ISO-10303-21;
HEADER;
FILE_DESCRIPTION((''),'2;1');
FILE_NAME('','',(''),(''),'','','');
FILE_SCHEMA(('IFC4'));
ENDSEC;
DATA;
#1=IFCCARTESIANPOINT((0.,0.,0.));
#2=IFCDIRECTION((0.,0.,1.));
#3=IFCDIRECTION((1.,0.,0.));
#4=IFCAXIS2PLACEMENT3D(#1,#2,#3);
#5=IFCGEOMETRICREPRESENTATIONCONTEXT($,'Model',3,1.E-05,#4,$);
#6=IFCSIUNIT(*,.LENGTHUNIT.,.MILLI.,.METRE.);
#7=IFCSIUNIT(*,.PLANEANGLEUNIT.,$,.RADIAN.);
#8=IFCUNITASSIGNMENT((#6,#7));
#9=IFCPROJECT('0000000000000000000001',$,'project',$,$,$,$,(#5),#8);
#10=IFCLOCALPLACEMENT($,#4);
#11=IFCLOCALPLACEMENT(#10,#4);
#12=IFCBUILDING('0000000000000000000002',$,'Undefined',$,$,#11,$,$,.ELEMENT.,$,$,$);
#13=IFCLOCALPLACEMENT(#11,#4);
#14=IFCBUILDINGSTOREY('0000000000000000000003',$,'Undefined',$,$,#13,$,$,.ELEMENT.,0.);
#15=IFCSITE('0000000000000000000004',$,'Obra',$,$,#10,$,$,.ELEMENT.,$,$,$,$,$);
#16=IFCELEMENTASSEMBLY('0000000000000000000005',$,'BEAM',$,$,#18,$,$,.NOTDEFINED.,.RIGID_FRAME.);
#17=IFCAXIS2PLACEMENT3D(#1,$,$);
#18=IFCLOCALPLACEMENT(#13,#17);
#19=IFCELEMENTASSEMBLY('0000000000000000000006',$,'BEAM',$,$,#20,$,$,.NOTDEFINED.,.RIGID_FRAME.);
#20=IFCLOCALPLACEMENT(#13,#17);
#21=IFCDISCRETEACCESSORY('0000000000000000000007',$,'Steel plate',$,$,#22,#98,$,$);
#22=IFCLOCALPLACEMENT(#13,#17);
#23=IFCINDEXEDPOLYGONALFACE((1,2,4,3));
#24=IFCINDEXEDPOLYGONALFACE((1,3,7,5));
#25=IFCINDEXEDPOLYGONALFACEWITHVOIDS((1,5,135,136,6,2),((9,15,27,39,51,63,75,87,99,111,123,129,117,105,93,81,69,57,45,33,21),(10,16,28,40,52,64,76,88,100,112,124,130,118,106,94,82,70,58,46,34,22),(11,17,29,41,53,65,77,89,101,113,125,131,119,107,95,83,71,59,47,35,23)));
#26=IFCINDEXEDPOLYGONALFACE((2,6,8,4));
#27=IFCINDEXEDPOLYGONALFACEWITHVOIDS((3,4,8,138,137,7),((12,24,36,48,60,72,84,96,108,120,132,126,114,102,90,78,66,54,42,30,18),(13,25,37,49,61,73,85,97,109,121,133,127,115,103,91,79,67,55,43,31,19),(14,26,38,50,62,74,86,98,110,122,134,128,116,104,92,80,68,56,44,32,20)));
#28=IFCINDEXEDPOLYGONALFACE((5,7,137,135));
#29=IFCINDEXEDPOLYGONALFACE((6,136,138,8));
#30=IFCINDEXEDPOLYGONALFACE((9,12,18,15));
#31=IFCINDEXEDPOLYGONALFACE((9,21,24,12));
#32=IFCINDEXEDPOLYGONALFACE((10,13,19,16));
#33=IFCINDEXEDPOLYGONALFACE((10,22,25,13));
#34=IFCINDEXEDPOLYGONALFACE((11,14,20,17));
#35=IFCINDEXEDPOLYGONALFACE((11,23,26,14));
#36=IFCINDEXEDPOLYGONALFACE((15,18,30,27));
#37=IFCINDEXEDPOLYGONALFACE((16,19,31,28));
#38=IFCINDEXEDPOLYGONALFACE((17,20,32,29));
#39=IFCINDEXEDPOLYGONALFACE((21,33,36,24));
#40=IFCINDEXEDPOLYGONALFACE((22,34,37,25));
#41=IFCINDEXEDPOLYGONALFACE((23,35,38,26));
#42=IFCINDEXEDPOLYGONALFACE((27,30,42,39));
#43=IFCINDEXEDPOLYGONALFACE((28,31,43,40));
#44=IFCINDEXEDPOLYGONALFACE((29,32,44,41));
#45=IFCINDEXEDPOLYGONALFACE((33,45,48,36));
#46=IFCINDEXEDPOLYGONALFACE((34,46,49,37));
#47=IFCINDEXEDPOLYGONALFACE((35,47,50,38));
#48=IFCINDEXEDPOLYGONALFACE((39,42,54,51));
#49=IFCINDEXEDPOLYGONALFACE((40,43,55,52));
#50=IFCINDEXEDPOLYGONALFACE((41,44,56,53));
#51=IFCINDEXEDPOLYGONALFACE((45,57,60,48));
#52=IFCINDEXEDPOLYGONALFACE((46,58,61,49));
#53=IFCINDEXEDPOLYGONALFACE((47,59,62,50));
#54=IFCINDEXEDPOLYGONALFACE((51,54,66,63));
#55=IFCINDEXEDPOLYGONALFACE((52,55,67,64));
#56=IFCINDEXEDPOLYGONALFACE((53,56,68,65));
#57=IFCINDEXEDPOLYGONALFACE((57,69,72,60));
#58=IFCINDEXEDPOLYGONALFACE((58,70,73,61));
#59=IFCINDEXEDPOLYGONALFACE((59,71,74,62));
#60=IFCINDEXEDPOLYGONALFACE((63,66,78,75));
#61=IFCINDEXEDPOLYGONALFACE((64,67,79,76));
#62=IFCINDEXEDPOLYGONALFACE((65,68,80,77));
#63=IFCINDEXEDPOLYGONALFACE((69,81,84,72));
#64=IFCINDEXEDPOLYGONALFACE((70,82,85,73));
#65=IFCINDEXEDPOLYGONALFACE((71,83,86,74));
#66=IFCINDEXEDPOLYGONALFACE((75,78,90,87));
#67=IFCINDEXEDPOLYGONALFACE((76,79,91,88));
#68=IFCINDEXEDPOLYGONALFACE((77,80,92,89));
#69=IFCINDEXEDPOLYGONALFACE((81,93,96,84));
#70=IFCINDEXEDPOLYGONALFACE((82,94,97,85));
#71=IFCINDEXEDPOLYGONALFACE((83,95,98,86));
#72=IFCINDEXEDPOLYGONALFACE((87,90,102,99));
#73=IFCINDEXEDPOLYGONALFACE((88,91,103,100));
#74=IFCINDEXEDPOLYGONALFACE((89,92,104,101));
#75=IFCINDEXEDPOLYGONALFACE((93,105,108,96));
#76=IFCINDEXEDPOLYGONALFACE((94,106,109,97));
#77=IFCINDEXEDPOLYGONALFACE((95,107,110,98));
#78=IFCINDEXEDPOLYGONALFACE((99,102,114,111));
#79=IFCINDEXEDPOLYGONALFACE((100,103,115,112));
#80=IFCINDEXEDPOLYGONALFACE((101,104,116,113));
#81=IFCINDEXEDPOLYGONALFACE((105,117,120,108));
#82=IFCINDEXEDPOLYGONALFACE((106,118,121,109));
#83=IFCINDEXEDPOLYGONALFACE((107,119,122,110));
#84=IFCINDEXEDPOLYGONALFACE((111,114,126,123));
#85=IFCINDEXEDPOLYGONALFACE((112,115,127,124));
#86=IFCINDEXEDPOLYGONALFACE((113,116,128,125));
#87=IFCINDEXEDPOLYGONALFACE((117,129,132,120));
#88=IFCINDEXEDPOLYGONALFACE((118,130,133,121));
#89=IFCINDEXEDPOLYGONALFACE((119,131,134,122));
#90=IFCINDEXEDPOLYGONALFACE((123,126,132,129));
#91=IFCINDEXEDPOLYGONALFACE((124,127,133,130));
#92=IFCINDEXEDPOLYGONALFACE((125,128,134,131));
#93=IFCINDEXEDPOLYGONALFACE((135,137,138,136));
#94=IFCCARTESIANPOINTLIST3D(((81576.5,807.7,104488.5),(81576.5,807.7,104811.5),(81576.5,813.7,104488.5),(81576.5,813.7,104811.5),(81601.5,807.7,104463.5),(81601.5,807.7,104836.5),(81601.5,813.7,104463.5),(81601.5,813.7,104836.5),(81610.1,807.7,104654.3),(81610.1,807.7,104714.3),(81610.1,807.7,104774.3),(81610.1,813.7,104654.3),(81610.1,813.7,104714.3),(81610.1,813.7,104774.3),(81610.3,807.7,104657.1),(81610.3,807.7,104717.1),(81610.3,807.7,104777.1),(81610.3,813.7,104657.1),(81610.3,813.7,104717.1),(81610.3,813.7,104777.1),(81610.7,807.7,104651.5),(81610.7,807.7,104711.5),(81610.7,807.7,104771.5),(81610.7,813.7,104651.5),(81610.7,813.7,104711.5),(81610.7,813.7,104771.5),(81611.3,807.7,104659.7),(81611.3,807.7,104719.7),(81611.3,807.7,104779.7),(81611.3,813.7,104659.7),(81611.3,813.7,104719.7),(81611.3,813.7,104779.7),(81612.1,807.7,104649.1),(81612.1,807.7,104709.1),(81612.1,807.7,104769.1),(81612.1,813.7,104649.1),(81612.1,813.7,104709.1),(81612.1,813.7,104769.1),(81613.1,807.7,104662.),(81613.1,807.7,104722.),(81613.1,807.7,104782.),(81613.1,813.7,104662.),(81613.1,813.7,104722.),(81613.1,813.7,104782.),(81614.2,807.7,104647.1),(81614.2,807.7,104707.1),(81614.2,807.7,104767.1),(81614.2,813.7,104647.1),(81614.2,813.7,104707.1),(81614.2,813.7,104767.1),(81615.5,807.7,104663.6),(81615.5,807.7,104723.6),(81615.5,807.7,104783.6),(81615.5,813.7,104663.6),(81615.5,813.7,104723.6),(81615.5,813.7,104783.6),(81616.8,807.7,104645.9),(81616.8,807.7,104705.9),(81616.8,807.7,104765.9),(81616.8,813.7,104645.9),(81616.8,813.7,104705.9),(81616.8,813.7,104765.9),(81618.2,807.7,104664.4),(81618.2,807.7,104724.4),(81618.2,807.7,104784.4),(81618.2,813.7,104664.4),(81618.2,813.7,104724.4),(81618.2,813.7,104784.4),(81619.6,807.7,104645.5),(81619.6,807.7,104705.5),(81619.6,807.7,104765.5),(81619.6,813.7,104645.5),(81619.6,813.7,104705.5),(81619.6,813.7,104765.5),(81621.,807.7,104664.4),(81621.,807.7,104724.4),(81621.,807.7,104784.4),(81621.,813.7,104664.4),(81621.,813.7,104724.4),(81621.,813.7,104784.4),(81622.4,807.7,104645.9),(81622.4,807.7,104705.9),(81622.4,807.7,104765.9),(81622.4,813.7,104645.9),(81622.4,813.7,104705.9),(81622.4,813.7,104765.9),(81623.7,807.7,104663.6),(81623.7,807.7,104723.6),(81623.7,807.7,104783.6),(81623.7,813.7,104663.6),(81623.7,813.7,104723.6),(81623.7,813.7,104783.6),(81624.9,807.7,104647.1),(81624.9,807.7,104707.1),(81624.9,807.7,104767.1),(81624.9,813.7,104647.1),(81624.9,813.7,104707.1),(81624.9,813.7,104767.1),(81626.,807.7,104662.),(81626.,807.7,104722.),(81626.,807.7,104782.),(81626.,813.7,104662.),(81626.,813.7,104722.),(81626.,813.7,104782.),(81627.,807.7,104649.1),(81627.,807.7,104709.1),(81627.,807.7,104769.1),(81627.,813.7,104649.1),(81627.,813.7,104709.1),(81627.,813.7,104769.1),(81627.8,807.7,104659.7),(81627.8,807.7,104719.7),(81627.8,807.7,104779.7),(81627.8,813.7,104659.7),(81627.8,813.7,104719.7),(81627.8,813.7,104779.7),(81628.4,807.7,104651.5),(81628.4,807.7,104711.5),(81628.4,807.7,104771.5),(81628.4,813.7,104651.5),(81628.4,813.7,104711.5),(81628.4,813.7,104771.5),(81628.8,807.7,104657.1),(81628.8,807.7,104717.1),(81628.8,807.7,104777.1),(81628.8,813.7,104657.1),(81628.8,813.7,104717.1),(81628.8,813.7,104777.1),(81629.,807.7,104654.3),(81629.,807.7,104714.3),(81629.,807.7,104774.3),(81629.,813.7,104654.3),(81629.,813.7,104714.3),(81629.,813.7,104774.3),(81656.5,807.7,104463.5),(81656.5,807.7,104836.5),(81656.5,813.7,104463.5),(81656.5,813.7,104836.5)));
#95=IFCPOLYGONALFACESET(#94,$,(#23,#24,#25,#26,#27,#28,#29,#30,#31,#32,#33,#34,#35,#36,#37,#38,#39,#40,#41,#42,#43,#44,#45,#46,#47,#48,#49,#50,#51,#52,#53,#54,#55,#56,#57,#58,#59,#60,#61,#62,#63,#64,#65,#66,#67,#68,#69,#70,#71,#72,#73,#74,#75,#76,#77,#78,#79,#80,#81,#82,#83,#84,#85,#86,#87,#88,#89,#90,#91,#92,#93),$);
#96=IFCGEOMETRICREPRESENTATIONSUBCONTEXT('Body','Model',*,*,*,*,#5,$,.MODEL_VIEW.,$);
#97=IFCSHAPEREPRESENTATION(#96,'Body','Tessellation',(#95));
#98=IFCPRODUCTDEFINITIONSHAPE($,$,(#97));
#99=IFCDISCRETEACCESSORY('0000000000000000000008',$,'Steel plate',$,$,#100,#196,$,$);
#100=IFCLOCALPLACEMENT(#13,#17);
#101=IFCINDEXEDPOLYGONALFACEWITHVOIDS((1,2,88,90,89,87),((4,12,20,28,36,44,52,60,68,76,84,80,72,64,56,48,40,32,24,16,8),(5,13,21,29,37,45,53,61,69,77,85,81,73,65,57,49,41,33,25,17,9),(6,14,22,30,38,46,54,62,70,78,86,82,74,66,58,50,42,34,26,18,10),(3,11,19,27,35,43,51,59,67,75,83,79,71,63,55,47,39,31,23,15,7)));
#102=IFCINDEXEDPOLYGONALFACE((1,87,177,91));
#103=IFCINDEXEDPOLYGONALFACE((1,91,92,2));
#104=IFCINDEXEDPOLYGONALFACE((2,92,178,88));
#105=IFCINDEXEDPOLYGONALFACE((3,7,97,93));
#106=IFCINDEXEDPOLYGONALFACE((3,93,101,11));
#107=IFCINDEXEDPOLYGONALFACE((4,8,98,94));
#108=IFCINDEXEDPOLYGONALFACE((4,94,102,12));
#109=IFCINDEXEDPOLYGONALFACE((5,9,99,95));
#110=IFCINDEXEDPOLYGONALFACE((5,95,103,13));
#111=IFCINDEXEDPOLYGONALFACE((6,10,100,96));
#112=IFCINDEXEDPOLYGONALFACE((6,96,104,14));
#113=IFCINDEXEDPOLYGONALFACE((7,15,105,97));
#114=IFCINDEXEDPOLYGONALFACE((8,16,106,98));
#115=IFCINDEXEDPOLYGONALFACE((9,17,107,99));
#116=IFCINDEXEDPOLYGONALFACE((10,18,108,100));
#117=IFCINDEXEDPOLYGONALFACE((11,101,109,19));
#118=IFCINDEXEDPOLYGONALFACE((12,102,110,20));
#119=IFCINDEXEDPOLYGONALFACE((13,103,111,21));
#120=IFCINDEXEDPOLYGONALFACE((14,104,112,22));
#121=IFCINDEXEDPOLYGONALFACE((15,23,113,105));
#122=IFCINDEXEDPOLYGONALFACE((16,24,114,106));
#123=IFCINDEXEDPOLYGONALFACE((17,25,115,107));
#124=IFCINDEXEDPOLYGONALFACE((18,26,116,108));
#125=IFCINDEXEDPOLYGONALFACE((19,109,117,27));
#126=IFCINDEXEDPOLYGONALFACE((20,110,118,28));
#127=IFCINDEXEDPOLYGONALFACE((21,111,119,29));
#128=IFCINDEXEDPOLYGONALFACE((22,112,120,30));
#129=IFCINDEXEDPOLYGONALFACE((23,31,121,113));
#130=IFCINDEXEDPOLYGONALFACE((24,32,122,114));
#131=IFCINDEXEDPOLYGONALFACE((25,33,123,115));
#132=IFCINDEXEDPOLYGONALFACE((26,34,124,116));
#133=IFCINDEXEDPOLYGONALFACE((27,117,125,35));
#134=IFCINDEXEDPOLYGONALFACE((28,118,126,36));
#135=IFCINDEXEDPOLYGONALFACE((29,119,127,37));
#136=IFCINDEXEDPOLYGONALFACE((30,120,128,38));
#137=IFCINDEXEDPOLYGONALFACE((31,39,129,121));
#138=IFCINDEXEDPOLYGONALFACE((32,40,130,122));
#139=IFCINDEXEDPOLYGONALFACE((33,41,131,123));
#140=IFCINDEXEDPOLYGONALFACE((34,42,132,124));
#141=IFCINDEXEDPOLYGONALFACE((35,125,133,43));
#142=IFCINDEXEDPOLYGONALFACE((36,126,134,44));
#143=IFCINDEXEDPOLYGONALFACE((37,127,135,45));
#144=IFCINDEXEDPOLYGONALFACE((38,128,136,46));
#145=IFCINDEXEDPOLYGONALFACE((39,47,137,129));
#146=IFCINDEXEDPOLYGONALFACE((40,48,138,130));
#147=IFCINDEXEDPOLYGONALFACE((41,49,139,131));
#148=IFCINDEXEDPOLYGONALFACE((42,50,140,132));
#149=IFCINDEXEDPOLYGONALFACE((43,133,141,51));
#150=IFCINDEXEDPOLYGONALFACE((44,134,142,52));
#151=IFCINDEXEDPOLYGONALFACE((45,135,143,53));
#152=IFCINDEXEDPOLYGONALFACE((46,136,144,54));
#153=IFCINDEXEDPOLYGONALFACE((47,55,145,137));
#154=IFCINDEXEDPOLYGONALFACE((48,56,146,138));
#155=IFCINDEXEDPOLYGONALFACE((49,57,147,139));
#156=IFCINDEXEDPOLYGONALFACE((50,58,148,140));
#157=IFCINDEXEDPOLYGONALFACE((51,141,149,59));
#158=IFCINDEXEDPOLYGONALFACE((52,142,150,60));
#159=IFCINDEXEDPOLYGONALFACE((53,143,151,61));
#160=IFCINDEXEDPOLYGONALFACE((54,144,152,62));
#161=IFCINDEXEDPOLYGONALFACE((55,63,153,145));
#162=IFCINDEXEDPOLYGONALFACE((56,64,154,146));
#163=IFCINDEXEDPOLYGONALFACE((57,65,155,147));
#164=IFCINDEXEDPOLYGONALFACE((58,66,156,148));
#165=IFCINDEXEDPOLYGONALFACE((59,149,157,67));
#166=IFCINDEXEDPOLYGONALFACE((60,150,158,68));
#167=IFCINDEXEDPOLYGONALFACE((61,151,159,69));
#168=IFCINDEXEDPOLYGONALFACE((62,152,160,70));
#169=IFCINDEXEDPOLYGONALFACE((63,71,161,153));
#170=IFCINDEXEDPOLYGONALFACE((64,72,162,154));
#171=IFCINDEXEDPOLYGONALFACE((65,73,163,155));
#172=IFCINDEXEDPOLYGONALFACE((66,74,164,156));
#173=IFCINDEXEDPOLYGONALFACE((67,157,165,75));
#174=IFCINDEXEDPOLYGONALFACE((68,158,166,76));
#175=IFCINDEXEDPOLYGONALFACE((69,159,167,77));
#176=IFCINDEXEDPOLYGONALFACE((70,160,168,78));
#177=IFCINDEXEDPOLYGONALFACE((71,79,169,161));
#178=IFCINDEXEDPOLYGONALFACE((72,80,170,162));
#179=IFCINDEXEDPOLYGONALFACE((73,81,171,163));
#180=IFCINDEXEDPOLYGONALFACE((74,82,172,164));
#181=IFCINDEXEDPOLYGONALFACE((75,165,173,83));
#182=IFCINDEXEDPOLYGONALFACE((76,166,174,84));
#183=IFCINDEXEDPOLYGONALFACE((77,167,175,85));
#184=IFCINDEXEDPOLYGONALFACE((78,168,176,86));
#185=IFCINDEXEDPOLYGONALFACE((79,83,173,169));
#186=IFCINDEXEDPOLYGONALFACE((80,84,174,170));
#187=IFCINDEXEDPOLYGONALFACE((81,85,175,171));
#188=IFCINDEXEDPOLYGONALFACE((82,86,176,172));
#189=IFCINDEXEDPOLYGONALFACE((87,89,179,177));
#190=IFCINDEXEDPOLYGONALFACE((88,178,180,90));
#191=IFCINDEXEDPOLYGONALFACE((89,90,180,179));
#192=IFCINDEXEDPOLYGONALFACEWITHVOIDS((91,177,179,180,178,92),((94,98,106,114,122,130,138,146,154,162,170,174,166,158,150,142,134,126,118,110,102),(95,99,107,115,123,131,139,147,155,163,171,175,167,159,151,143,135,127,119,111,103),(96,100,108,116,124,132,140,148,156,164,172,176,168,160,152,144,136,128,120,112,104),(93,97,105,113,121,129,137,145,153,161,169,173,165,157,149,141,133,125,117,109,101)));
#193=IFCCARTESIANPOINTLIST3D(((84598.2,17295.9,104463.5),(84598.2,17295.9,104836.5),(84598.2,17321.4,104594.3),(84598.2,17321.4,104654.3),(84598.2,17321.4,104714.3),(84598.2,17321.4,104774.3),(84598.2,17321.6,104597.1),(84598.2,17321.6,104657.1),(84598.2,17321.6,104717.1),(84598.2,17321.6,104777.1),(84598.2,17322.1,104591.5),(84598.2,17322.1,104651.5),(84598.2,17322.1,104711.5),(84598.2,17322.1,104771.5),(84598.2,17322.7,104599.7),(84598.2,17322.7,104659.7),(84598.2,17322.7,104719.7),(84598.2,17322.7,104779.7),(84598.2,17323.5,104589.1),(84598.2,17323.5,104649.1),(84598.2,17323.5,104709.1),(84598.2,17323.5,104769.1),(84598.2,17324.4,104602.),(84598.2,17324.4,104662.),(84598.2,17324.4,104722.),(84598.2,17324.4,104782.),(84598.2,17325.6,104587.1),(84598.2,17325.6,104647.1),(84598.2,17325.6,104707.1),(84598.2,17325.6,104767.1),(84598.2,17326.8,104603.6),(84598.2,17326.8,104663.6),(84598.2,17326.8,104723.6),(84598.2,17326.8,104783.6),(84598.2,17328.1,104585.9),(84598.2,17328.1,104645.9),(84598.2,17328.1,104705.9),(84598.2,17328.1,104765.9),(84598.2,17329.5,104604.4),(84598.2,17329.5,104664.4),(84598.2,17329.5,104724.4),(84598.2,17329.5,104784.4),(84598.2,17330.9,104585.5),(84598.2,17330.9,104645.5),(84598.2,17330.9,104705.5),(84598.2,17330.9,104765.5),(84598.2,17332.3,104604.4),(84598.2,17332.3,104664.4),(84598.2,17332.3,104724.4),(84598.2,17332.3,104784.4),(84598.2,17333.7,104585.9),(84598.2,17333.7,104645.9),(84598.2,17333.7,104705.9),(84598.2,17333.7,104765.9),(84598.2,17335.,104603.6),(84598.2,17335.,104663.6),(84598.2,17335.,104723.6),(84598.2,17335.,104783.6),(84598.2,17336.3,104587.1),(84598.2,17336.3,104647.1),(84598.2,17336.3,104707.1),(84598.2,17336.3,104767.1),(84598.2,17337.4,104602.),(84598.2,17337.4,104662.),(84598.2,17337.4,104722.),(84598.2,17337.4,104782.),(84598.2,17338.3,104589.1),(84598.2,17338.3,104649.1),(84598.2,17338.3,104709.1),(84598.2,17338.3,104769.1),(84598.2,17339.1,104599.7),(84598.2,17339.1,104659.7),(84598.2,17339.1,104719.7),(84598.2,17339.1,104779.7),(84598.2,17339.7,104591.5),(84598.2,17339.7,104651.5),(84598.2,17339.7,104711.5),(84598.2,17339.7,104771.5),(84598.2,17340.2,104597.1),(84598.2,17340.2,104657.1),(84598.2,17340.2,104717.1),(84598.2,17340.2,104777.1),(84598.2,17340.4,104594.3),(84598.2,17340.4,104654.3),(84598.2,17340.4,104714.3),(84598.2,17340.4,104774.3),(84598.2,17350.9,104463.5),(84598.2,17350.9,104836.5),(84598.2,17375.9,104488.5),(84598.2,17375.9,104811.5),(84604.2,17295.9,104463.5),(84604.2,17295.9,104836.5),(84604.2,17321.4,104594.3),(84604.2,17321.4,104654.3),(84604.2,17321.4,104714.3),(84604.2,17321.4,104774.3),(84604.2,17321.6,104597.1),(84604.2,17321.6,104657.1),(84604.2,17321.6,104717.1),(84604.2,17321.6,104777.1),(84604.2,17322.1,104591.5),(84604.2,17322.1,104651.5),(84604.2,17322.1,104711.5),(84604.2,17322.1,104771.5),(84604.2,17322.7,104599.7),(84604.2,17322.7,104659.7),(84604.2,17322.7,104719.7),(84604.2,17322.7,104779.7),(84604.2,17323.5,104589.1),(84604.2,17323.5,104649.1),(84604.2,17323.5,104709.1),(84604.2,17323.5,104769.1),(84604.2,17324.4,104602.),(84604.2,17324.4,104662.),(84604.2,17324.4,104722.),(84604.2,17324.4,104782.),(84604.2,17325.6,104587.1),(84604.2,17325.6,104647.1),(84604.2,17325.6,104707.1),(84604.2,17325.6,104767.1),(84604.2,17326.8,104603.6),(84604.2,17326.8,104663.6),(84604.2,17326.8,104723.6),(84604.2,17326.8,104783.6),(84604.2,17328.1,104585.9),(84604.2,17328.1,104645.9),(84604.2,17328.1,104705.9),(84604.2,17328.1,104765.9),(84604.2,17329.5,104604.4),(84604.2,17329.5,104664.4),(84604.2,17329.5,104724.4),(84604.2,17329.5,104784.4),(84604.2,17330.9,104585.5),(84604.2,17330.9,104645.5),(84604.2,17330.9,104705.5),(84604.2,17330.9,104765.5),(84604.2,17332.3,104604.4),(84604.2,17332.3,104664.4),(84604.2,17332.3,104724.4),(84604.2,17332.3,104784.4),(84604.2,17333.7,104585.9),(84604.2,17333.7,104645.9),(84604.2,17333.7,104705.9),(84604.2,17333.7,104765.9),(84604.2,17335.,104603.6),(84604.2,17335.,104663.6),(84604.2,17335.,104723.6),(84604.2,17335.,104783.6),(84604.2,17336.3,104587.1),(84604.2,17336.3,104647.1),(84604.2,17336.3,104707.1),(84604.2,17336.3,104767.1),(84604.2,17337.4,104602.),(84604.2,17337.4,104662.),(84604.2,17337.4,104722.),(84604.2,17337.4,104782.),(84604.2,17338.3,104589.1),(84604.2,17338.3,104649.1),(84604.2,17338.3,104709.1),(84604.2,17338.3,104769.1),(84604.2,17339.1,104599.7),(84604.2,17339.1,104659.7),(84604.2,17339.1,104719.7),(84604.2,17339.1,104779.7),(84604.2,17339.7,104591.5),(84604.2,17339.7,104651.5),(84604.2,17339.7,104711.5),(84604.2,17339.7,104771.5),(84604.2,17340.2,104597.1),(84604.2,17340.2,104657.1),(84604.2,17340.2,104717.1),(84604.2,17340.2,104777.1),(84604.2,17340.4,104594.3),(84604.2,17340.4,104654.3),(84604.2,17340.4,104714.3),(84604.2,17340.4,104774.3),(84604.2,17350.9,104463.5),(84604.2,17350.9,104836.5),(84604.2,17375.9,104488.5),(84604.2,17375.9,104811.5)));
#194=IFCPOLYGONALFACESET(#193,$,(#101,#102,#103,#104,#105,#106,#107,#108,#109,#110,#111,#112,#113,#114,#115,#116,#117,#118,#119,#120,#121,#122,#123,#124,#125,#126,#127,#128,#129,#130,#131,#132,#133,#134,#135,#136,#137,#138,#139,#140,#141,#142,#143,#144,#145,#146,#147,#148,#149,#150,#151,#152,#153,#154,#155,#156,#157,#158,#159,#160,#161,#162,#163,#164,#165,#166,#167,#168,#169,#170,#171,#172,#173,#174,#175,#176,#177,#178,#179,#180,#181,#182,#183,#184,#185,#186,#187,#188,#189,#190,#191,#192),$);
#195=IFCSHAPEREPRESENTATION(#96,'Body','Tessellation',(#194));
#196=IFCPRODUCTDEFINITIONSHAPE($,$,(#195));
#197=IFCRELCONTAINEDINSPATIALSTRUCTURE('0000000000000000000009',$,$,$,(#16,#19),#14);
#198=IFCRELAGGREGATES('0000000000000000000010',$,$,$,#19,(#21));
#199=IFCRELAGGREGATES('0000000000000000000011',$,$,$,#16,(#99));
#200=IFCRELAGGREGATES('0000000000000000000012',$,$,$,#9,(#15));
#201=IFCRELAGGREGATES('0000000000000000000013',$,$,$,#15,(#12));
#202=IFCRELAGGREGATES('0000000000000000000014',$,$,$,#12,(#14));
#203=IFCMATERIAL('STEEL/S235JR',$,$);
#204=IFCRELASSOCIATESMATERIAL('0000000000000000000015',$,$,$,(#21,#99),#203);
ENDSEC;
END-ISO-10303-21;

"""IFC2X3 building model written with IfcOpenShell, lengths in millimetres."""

from ifc_helpers import new_model, si_unit, frame, origin_with_axes, origin_2d_with_axis, place, context, subcontext, project, spatial, polyline, circle, outline, extrude, source, transform, mapped, material, element, aggregate, save


model = new_model("IFC2X3")

# Units and contexts
model_context = context("Model", 3, precision=1e-05, world=origin_with_axes())
body_context = subcontext(model_context, "Body", "Model", "MODEL_VIEW")
ifc_project = project(units=[si_unit("LENGTHUNIT", "METRE", prefix="MILLI"), si_unit("PLANEANGLEUNIT", "RADIAN")], contexts=[model_context])

# Site, building, storey
site_placement = place(None, origin_with_axes())
site = spatial("IfcSite", under=ifc_project, at=site_placement, Name="Obra", CompositionType="ELEMENT")
building_placement = place(site_placement, origin_with_axes())
building = spatial("IfcBuilding", under=site, at=building_placement, Name="Undefined", CompositionType="ELEMENT")
storey_placement = place(building_placement, origin_with_axes())
storey = spatial("IfcBuildingStorey", under=building, at=storey_placement, Name="Undefined", CompositionType="ELEMENT", Elevation=0.0)

# Shared definitions
ifc_material = material(Name="STEEL/S235JR")

# Element assembly
assembly_1_placement = place(storey_placement, origin_with_axes())
assembly_1 = element("IfcElementAssembly", 1, at=assembly_1_placement, inside=storey, Name="BEAM", AssemblyPlace="NOTDEFINED", PredefinedType="RIGID_FRAME")

# Element assembly, discrete accessory, opening
assembly_2_placement = place(storey_placement, origin_with_axes())
assembly_2 = element("IfcElementAssembly", 2, at=assembly_2_placement, inside=storey, Name="BEAM", AssemblyPlace="NOTDEFINED", PredefinedType="RIGID_FRAME")
discrete_accessory_1_placement = place(assembly_2_placement, frame((81656.5, 810.7, 104463.5), z_axis=(0.0, 1.0, 0.0), x_axis=(-1.0, 0.0, 0.0)))
discrete_accessory_1 = element("IfcDiscreteAccessory", 3, at=discrete_accessory_1_placement, material=ifc_material, Name="Steel plate", context=body_context, shape_type="SweptSolid", body=[
    extrude(outline(polyline([(0.0, 0.0), (55.0, 0.0), (80.0, 25.0), (80.0, 348.0), (55.0, 373.0), (0.0, 373.0), (0.0, 0.0)])), frame((0.0, 0.0, -3.0), z_axis=(0.0, 0.0, 1.0), x_axis=(1.0, 0.0, 0.0)), (0.0, 0.0, 1.0), 6.0),
])
shared_shape_1 = source(origin_with_axes(), body_context, "Body", "SweptSolid", [
    extrude(circle(Radius=9.5, at=origin_2d_with_axis()), frame((0.0, -10.1, 0.0), z_axis=(0.0, 1.0, 0.0), x_axis=(1.0, 0.0, 0.0)), (0.0, 0.0, 1.0), 6.2),
])
opening_1_placement = place(assembly_2_placement, frame((81584.6, 817.7, 104850.0), z_axis=(1.0, 0.0, 0.0), x_axis=(0.0, 0.0, -1.0)))
element("IfcOpeningElement", 4, at=opening_1_placement, cuts=discrete_accessory_1, ObjectType="Opening", context=body_context, shape_type="MappedRepresentation", body=[
    mapped(shared_shape_1, transform((75.0, 0.0, 35.0))),
    mapped(shared_shape_1, transform((135.0, 0.0, 35.0))),
    mapped(shared_shape_1, transform((195.0, 0.0, 35.0))),
])
aggregate(assembly_2, [discrete_accessory_1])

# Discrete accessory, opening
discrete_accessory_2_placement = place(assembly_1_placement, frame((84601.2, 17295.9, 104463.5), z_axis=(1.0, 0.0, 0.0), x_axis=(0.0, 1.0, 0.0)))
discrete_accessory_2 = element("IfcDiscreteAccessory", 5, at=discrete_accessory_2_placement, material=ifc_material, Name="Steel plate", context=body_context, shape_type="SweptSolid", body=[
    extrude(outline(polyline([(0.0, 0.0), (55.0, 0.0), (80.0, 25.0), (80.0, 348.0), (55.0, 373.0), (0.0, 373.0), (0.0, 0.0)])), frame((0.0, 0.0, -3.0), z_axis=(0.0, 0.0, 1.0), x_axis=(1.0, 0.0, 0.0)), (0.0, 0.0, 1.0), 6.0),
])
shared_shape_2 = source(origin_with_axes(), body_context, "Body", "SweptSolid", [
    extrude(circle(Radius=9.5, at=origin_2d_with_axis()), frame((0.0, -9.9, 0.0), z_axis=(0.0, 1.0, 0.0), x_axis=(1.0, 0.0, 0.0)), (0.0, 0.0, 1.0), 6.2),
])
opening_2_placement = place(assembly_1_placement, frame((84607.9, 17365.9, 104850.0), z_axis=(0.0, -1.0, 0.0), x_axis=(0.0, 0.0, -1.0)))
element("IfcOpeningElement", 6, at=opening_2_placement, cuts=discrete_accessory_2, ObjectType="Opening", context=body_context, shape_type="MappedRepresentation", body=[
    mapped(shared_shape_2, transform((75.0, 0.0, 35.0))),
    mapped(shared_shape_2, transform((135.0, 0.0, 35.0))),
    mapped(shared_shape_2, transform((195.0, 0.0, 35.0))),
    mapped(shared_shape_2, transform((255.0, 0.0, 35.0))),
])
aggregate(assembly_1, [discrete_accessory_2])

save(model, "model.ifc")
